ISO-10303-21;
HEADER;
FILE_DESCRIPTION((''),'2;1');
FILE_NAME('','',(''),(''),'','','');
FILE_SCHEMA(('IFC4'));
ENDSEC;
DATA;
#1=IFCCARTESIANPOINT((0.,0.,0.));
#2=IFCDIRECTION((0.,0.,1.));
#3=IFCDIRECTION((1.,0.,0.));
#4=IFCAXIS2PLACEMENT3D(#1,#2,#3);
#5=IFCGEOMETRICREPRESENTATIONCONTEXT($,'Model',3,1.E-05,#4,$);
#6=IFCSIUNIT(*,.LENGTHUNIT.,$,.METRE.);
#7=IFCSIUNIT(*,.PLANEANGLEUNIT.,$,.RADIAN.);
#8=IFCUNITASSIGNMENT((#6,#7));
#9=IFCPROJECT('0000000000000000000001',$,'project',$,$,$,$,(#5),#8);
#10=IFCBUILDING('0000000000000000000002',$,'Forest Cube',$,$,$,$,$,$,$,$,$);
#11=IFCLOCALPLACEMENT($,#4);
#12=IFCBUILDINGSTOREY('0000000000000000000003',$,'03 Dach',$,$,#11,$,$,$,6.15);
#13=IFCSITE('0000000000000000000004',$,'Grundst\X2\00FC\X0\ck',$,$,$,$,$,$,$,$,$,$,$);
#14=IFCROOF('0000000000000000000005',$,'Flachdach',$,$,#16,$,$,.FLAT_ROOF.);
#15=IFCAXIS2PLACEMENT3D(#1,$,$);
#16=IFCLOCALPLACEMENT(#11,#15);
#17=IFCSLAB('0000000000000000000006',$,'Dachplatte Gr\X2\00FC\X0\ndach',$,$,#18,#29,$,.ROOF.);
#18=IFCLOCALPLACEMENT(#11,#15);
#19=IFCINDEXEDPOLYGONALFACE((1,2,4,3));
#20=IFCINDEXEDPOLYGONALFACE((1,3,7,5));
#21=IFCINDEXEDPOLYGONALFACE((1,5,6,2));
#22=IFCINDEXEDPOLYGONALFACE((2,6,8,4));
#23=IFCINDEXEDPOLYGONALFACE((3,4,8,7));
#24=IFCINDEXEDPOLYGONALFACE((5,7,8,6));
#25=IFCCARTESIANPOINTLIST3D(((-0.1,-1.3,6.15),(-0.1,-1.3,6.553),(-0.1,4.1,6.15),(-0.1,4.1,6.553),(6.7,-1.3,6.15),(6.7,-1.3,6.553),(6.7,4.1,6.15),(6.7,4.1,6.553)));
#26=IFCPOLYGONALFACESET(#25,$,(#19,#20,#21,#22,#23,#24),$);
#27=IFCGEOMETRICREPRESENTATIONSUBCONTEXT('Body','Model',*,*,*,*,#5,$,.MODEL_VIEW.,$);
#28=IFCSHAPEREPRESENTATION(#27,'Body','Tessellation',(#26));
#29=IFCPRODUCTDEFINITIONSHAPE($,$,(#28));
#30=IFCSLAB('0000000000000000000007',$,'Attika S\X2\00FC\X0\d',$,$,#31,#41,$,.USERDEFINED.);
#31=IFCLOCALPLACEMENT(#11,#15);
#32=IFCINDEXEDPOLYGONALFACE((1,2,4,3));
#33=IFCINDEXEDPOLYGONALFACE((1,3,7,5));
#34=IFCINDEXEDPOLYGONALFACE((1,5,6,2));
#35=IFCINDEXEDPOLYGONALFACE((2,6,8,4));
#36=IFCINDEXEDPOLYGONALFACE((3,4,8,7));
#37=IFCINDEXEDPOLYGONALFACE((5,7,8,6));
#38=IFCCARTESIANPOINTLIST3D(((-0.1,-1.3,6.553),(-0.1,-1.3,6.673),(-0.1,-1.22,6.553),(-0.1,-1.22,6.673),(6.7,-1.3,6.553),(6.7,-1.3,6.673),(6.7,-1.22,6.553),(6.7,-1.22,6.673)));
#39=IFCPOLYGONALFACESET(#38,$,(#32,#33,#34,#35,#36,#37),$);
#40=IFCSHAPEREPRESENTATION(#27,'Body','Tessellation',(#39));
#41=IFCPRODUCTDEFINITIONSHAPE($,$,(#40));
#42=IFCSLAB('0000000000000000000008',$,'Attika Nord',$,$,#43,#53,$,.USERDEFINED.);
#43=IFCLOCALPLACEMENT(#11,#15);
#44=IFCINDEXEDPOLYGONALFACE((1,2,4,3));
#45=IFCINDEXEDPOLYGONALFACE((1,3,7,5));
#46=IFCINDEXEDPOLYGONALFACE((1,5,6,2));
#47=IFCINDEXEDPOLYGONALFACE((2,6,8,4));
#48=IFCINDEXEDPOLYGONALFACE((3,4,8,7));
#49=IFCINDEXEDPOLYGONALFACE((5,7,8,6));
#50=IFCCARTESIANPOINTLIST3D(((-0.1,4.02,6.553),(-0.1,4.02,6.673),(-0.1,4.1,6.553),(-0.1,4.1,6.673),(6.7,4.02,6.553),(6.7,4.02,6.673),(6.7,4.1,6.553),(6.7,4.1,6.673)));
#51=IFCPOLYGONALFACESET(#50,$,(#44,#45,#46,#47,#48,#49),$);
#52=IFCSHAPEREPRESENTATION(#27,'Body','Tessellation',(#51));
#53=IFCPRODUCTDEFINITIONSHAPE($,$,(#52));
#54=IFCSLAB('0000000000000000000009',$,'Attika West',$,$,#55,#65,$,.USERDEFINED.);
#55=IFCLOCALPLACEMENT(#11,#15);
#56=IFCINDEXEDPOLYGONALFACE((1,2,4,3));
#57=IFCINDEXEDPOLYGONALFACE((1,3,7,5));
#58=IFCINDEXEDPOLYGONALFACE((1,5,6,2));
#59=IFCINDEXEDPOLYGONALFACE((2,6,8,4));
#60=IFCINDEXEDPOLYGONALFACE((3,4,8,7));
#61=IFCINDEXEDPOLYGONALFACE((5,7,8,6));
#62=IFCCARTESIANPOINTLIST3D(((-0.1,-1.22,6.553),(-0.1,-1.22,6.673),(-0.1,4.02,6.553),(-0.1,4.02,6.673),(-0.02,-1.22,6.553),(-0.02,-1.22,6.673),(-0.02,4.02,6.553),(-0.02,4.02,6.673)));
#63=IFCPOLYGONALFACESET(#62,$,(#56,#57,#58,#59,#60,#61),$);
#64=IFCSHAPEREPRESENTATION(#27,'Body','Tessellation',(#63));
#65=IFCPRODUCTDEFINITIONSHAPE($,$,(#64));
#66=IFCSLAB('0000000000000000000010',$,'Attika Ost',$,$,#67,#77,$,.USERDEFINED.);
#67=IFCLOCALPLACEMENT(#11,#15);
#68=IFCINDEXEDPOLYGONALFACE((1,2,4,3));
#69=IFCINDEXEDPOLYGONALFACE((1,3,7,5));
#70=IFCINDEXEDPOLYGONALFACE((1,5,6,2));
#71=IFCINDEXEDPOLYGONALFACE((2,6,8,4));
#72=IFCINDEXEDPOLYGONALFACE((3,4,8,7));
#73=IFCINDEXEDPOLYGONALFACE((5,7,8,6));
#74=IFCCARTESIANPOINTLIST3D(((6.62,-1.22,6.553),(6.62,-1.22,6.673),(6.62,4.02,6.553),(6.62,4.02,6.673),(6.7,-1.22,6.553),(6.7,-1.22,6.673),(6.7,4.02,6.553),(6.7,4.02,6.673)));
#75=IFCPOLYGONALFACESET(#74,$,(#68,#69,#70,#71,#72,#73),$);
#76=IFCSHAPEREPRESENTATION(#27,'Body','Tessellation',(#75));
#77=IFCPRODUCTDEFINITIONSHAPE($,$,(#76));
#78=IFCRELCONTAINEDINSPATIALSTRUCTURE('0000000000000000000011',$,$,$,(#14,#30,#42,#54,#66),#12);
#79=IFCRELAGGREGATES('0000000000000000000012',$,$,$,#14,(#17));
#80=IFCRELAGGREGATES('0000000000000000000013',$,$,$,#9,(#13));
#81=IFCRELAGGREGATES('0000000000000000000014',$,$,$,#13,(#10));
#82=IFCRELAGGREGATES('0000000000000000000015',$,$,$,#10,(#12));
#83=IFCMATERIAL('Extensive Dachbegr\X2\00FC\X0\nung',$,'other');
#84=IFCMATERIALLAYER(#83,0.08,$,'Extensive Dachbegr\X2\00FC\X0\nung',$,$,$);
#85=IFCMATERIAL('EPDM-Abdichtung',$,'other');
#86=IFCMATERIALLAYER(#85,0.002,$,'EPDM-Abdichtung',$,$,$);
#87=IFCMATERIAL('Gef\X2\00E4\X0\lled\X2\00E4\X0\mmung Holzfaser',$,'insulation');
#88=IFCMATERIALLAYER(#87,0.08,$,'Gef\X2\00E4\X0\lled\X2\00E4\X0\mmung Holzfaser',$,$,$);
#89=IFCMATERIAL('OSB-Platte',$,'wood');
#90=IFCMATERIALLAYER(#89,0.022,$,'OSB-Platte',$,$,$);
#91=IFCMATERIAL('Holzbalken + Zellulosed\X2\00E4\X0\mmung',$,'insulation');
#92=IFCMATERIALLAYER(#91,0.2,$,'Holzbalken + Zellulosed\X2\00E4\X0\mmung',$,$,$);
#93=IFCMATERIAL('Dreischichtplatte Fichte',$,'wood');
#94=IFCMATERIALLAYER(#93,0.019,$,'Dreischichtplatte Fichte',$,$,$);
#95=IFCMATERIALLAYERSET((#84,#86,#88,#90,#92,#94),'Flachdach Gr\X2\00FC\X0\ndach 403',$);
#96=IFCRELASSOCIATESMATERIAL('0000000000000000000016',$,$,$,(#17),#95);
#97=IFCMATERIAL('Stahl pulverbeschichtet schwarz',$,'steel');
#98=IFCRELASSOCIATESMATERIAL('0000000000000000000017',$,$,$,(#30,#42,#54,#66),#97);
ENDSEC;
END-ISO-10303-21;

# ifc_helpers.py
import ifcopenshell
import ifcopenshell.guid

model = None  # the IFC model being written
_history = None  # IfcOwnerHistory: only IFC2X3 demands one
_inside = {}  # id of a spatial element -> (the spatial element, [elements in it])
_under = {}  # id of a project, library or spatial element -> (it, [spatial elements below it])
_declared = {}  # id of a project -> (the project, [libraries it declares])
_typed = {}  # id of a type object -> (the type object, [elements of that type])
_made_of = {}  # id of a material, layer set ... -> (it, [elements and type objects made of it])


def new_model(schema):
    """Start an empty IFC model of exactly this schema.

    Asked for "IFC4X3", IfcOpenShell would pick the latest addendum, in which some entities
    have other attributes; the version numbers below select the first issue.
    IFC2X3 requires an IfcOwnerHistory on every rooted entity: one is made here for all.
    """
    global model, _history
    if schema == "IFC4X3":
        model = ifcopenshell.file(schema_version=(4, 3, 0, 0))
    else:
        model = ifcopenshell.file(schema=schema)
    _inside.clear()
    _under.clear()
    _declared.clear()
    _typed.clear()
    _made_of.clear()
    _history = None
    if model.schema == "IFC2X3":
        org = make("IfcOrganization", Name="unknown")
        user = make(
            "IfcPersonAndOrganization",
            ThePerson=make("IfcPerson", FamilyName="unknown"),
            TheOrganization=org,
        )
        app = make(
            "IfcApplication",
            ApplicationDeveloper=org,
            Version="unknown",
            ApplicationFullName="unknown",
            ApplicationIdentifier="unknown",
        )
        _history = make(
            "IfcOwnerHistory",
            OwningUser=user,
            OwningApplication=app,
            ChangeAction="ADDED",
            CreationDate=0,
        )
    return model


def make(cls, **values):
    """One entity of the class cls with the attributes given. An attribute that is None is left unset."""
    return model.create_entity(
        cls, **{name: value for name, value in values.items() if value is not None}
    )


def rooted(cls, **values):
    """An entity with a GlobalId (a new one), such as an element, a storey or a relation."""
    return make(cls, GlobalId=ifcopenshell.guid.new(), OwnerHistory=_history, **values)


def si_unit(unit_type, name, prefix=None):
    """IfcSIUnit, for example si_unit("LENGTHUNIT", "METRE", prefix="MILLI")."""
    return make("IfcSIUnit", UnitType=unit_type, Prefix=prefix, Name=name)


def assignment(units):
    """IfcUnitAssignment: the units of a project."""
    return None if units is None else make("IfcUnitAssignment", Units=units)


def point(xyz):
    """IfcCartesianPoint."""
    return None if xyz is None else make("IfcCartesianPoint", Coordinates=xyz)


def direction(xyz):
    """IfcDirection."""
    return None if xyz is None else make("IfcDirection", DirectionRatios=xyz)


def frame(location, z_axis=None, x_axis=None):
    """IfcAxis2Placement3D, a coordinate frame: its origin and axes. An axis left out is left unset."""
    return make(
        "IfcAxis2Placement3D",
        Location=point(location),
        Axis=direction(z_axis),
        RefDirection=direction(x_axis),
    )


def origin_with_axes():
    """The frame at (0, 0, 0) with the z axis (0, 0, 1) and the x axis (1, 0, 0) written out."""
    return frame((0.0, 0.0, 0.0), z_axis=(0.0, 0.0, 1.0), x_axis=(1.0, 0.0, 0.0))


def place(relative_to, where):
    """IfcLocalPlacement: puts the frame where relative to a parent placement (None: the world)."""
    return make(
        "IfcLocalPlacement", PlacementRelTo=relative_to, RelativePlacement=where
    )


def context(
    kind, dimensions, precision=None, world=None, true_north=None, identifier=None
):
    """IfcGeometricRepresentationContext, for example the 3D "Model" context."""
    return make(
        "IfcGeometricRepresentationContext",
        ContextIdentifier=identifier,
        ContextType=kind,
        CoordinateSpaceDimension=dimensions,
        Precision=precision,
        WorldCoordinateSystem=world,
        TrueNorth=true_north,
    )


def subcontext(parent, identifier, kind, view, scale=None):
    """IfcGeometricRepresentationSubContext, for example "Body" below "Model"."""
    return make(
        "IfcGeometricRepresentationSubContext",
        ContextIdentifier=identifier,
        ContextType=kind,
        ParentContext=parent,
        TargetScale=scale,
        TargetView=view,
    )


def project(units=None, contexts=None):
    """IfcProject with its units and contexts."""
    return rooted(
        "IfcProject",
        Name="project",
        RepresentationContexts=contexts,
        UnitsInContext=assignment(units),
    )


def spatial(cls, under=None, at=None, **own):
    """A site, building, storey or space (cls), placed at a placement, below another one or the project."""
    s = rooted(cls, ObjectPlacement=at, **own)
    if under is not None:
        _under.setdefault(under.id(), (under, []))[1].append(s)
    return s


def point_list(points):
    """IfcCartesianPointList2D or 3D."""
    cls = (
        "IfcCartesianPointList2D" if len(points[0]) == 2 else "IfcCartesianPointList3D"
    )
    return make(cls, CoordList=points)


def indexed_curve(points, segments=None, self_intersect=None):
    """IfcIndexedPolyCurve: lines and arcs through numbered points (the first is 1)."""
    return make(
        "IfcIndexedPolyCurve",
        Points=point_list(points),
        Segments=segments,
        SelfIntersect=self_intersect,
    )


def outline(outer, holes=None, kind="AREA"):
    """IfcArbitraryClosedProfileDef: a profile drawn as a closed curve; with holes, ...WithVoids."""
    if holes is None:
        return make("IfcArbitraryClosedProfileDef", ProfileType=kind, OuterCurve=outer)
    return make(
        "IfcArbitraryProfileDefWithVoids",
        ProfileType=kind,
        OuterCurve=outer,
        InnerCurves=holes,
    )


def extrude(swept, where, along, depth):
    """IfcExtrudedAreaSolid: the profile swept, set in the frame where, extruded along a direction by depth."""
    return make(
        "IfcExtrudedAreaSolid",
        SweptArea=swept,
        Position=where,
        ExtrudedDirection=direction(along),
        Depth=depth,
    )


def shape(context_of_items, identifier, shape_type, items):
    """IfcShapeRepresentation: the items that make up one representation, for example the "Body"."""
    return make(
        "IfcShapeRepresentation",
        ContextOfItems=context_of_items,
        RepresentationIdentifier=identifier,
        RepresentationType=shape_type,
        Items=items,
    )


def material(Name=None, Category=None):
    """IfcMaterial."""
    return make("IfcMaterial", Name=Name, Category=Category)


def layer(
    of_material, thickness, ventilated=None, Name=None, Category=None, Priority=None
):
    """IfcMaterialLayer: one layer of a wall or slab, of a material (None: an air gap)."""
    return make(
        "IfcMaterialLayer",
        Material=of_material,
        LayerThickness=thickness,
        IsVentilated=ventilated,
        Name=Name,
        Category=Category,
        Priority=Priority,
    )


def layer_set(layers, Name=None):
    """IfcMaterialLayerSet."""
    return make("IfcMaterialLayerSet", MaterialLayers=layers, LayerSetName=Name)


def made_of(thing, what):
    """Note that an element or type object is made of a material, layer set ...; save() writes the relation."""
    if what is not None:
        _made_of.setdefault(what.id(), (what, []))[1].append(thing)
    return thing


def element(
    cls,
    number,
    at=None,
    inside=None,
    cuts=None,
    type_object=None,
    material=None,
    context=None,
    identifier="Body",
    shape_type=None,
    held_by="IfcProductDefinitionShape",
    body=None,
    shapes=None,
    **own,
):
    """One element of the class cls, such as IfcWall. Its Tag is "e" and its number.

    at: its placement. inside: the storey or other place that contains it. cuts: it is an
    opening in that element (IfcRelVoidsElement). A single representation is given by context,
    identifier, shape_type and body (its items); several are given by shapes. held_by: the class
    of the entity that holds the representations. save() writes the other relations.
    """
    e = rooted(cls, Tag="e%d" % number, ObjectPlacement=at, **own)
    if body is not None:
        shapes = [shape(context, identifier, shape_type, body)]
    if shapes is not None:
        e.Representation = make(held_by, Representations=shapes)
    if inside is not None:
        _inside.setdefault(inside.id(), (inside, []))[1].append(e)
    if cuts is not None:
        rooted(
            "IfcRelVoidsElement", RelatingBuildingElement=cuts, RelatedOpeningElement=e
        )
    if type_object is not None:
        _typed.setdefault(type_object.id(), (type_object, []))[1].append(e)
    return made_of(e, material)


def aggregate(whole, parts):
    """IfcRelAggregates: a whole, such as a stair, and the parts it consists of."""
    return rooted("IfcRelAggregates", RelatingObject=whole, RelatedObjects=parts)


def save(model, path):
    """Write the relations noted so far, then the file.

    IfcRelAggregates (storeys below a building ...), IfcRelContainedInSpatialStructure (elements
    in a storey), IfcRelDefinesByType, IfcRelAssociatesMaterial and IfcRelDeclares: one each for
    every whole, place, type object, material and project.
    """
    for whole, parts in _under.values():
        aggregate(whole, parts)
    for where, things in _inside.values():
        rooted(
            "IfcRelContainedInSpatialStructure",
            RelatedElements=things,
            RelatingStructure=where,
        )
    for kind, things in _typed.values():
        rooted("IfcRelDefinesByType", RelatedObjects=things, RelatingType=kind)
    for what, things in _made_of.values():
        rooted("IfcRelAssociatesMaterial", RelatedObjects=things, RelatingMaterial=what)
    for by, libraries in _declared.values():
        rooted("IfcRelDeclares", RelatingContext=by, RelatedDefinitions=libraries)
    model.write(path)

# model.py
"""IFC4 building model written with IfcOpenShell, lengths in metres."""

from ifc_helpers import new_model, si_unit, frame, origin_with_axes, place, context, subcontext, project, spatial, indexed_curve, outline, extrude, material, layer, layer_set, element, aggregate, save


model = new_model("IFC4")

# Units and contexts
model_context = context("Model", 3, precision=1e-05, world=origin_with_axes())
body_context = subcontext(model_context, "Body", "Model", "MODEL_VIEW")
ifc_project = project(units=[si_unit("LENGTHUNIT", "METRE"), si_unit("PLANEANGLEUNIT", "RADIAN")], contexts=[model_context])

# Site, building, storey
site = spatial("IfcSite", under=ifc_project, Name="Grundstück")
building = spatial("IfcBuilding", under=site, Name="Forest Cube")
storey_placement = place(None, origin_with_axes())
storey = spatial("IfcBuildingStorey", under=building, at=storey_placement, Name="03 Dach", Elevation=6.15)

# Roof, slab
roof_placement = place(storey_placement, origin_with_axes())
roof = element("IfcRoof", 1, at=roof_placement, inside=storey, Name="Flachdach", PredefinedType="FLAT_ROOF")
ifc_material_1 = material(Name="Extensive Dachbegrünung", Category="other")
ifc_layer_1 = layer(ifc_material_1, 0.08, Name="Extensive Dachbegrünung")
ifc_material_2 = material(Name="EPDM-Abdichtung", Category="other")
ifc_layer_2 = layer(ifc_material_2, 0.002, Name="EPDM-Abdichtung")
ifc_material_3 = material(Name="Gefälledämmung Holzfaser", Category="insulation")
ifc_layer_3 = layer(ifc_material_3, 0.08, Name="Gefälledämmung Holzfaser")
ifc_material_4 = material(Name="OSB-Platte", Category="wood")
ifc_layer_4 = layer(ifc_material_4, 0.022, Name="OSB-Platte")
ifc_material_5 = material(Name="Holzbalken + Zellulosedämmung", Category="insulation")
ifc_layer_5 = layer(ifc_material_5, 0.2, Name="Holzbalken + Zellulosedämmung")
ifc_material_6 = material(Name="Dreischichtplatte Fichte", Category="wood")
ifc_layer_6 = layer(ifc_material_6, 0.019, Name="Dreischichtplatte Fichte")
ifc_layer_set = layer_set([ifc_layer_1, ifc_layer_2, ifc_layer_3, ifc_layer_4, ifc_layer_5, ifc_layer_6], Name="Flachdach Gründach 403")
slab_1_placement = place(roof_placement, frame((0.0, 0.0, 6.15), z_axis=(0.0, 0.0, 1.0), x_axis=(1.0, 0.0, 0.0)))
slab_1 = element("IfcSlab", 2, at=slab_1_placement, material=ifc_layer_set, Name="Dachplatte Gründach", PredefinedType="ROOF", context=body_context, shape_type="SweptSolid", body=[
    extrude(outline(indexed_curve([(-0.1, -1.3), (6.7, -1.3), (6.7, 4.1), (-0.1, 4.1)])), None, (0.0, 0.0, 1.0), 0.403),
])
aggregate(roof, [slab_1])

# Slabs
ifc_material_7 = material(Name="Stahl pulverbeschichtet schwarz", Category="steel")
slab_2_placement = place(storey_placement, frame((0.0, 0.0, 6.553), z_axis=(0.0, 0.0, 1.0), x_axis=(1.0, 0.0, 0.0)))
element("IfcSlab", 3, at=slab_2_placement, inside=storey, material=ifc_material_7, Name="Attika Süd", PredefinedType="USERDEFINED", context=body_context, shape_type="SweptSolid", body=[
    extrude(outline(indexed_curve([(-0.1, -1.3), (6.7, -1.3), (6.7, -1.22), (-0.1, -1.22)])), None, (0.0, 0.0, 1.0), 0.12),
])
slab_3_placement = place(storey_placement, frame((0.0, 0.0, 6.553), z_axis=(0.0, 0.0, 1.0), x_axis=(1.0, 0.0, 0.0)))
element("IfcSlab", 4, at=slab_3_placement, inside=storey, material=ifc_material_7, Name="Attika Nord", PredefinedType="USERDEFINED", context=body_context, shape_type="SweptSolid", body=[
    extrude(outline(indexed_curve([(-0.1, 4.02), (6.7, 4.02), (6.7, 4.1), (-0.1, 4.1)])), None, (0.0, 0.0, 1.0), 0.12),
])
slab_4_placement = place(storey_placement, frame((0.0, 0.0, 6.553), z_axis=(0.0, 0.0, 1.0), x_axis=(1.0, 0.0, 0.0)))
element("IfcSlab", 5, at=slab_4_placement, inside=storey, material=ifc_material_7, Name="Attika West", PredefinedType="USERDEFINED", context=body_context, shape_type="SweptSolid", body=[
    extrude(outline(indexed_curve([(-0.1, -1.22), (-0.02, -1.22), (-0.02, 4.02), (-0.1, 4.02)])), None, (0.0, 0.0, 1.0), 0.12),
])
slab_5_placement = place(storey_placement, frame((0.0, 0.0, 6.553), z_axis=(0.0, 0.0, 1.0), x_axis=(1.0, 0.0, 0.0)))
element("IfcSlab", 6, at=slab_5_placement, inside=storey, material=ifc_material_7, Name="Attika Ost", PredefinedType="USERDEFINED", context=body_context, shape_type="SweptSolid", body=[
    extrude(outline(indexed_curve([(6.62, -1.22), (6.7, -1.22), (6.7, 4.02), (6.62, 4.02)])), None, (0.0, 0.0, 1.0), 0.12),
])

save(model, "model.ifc")
